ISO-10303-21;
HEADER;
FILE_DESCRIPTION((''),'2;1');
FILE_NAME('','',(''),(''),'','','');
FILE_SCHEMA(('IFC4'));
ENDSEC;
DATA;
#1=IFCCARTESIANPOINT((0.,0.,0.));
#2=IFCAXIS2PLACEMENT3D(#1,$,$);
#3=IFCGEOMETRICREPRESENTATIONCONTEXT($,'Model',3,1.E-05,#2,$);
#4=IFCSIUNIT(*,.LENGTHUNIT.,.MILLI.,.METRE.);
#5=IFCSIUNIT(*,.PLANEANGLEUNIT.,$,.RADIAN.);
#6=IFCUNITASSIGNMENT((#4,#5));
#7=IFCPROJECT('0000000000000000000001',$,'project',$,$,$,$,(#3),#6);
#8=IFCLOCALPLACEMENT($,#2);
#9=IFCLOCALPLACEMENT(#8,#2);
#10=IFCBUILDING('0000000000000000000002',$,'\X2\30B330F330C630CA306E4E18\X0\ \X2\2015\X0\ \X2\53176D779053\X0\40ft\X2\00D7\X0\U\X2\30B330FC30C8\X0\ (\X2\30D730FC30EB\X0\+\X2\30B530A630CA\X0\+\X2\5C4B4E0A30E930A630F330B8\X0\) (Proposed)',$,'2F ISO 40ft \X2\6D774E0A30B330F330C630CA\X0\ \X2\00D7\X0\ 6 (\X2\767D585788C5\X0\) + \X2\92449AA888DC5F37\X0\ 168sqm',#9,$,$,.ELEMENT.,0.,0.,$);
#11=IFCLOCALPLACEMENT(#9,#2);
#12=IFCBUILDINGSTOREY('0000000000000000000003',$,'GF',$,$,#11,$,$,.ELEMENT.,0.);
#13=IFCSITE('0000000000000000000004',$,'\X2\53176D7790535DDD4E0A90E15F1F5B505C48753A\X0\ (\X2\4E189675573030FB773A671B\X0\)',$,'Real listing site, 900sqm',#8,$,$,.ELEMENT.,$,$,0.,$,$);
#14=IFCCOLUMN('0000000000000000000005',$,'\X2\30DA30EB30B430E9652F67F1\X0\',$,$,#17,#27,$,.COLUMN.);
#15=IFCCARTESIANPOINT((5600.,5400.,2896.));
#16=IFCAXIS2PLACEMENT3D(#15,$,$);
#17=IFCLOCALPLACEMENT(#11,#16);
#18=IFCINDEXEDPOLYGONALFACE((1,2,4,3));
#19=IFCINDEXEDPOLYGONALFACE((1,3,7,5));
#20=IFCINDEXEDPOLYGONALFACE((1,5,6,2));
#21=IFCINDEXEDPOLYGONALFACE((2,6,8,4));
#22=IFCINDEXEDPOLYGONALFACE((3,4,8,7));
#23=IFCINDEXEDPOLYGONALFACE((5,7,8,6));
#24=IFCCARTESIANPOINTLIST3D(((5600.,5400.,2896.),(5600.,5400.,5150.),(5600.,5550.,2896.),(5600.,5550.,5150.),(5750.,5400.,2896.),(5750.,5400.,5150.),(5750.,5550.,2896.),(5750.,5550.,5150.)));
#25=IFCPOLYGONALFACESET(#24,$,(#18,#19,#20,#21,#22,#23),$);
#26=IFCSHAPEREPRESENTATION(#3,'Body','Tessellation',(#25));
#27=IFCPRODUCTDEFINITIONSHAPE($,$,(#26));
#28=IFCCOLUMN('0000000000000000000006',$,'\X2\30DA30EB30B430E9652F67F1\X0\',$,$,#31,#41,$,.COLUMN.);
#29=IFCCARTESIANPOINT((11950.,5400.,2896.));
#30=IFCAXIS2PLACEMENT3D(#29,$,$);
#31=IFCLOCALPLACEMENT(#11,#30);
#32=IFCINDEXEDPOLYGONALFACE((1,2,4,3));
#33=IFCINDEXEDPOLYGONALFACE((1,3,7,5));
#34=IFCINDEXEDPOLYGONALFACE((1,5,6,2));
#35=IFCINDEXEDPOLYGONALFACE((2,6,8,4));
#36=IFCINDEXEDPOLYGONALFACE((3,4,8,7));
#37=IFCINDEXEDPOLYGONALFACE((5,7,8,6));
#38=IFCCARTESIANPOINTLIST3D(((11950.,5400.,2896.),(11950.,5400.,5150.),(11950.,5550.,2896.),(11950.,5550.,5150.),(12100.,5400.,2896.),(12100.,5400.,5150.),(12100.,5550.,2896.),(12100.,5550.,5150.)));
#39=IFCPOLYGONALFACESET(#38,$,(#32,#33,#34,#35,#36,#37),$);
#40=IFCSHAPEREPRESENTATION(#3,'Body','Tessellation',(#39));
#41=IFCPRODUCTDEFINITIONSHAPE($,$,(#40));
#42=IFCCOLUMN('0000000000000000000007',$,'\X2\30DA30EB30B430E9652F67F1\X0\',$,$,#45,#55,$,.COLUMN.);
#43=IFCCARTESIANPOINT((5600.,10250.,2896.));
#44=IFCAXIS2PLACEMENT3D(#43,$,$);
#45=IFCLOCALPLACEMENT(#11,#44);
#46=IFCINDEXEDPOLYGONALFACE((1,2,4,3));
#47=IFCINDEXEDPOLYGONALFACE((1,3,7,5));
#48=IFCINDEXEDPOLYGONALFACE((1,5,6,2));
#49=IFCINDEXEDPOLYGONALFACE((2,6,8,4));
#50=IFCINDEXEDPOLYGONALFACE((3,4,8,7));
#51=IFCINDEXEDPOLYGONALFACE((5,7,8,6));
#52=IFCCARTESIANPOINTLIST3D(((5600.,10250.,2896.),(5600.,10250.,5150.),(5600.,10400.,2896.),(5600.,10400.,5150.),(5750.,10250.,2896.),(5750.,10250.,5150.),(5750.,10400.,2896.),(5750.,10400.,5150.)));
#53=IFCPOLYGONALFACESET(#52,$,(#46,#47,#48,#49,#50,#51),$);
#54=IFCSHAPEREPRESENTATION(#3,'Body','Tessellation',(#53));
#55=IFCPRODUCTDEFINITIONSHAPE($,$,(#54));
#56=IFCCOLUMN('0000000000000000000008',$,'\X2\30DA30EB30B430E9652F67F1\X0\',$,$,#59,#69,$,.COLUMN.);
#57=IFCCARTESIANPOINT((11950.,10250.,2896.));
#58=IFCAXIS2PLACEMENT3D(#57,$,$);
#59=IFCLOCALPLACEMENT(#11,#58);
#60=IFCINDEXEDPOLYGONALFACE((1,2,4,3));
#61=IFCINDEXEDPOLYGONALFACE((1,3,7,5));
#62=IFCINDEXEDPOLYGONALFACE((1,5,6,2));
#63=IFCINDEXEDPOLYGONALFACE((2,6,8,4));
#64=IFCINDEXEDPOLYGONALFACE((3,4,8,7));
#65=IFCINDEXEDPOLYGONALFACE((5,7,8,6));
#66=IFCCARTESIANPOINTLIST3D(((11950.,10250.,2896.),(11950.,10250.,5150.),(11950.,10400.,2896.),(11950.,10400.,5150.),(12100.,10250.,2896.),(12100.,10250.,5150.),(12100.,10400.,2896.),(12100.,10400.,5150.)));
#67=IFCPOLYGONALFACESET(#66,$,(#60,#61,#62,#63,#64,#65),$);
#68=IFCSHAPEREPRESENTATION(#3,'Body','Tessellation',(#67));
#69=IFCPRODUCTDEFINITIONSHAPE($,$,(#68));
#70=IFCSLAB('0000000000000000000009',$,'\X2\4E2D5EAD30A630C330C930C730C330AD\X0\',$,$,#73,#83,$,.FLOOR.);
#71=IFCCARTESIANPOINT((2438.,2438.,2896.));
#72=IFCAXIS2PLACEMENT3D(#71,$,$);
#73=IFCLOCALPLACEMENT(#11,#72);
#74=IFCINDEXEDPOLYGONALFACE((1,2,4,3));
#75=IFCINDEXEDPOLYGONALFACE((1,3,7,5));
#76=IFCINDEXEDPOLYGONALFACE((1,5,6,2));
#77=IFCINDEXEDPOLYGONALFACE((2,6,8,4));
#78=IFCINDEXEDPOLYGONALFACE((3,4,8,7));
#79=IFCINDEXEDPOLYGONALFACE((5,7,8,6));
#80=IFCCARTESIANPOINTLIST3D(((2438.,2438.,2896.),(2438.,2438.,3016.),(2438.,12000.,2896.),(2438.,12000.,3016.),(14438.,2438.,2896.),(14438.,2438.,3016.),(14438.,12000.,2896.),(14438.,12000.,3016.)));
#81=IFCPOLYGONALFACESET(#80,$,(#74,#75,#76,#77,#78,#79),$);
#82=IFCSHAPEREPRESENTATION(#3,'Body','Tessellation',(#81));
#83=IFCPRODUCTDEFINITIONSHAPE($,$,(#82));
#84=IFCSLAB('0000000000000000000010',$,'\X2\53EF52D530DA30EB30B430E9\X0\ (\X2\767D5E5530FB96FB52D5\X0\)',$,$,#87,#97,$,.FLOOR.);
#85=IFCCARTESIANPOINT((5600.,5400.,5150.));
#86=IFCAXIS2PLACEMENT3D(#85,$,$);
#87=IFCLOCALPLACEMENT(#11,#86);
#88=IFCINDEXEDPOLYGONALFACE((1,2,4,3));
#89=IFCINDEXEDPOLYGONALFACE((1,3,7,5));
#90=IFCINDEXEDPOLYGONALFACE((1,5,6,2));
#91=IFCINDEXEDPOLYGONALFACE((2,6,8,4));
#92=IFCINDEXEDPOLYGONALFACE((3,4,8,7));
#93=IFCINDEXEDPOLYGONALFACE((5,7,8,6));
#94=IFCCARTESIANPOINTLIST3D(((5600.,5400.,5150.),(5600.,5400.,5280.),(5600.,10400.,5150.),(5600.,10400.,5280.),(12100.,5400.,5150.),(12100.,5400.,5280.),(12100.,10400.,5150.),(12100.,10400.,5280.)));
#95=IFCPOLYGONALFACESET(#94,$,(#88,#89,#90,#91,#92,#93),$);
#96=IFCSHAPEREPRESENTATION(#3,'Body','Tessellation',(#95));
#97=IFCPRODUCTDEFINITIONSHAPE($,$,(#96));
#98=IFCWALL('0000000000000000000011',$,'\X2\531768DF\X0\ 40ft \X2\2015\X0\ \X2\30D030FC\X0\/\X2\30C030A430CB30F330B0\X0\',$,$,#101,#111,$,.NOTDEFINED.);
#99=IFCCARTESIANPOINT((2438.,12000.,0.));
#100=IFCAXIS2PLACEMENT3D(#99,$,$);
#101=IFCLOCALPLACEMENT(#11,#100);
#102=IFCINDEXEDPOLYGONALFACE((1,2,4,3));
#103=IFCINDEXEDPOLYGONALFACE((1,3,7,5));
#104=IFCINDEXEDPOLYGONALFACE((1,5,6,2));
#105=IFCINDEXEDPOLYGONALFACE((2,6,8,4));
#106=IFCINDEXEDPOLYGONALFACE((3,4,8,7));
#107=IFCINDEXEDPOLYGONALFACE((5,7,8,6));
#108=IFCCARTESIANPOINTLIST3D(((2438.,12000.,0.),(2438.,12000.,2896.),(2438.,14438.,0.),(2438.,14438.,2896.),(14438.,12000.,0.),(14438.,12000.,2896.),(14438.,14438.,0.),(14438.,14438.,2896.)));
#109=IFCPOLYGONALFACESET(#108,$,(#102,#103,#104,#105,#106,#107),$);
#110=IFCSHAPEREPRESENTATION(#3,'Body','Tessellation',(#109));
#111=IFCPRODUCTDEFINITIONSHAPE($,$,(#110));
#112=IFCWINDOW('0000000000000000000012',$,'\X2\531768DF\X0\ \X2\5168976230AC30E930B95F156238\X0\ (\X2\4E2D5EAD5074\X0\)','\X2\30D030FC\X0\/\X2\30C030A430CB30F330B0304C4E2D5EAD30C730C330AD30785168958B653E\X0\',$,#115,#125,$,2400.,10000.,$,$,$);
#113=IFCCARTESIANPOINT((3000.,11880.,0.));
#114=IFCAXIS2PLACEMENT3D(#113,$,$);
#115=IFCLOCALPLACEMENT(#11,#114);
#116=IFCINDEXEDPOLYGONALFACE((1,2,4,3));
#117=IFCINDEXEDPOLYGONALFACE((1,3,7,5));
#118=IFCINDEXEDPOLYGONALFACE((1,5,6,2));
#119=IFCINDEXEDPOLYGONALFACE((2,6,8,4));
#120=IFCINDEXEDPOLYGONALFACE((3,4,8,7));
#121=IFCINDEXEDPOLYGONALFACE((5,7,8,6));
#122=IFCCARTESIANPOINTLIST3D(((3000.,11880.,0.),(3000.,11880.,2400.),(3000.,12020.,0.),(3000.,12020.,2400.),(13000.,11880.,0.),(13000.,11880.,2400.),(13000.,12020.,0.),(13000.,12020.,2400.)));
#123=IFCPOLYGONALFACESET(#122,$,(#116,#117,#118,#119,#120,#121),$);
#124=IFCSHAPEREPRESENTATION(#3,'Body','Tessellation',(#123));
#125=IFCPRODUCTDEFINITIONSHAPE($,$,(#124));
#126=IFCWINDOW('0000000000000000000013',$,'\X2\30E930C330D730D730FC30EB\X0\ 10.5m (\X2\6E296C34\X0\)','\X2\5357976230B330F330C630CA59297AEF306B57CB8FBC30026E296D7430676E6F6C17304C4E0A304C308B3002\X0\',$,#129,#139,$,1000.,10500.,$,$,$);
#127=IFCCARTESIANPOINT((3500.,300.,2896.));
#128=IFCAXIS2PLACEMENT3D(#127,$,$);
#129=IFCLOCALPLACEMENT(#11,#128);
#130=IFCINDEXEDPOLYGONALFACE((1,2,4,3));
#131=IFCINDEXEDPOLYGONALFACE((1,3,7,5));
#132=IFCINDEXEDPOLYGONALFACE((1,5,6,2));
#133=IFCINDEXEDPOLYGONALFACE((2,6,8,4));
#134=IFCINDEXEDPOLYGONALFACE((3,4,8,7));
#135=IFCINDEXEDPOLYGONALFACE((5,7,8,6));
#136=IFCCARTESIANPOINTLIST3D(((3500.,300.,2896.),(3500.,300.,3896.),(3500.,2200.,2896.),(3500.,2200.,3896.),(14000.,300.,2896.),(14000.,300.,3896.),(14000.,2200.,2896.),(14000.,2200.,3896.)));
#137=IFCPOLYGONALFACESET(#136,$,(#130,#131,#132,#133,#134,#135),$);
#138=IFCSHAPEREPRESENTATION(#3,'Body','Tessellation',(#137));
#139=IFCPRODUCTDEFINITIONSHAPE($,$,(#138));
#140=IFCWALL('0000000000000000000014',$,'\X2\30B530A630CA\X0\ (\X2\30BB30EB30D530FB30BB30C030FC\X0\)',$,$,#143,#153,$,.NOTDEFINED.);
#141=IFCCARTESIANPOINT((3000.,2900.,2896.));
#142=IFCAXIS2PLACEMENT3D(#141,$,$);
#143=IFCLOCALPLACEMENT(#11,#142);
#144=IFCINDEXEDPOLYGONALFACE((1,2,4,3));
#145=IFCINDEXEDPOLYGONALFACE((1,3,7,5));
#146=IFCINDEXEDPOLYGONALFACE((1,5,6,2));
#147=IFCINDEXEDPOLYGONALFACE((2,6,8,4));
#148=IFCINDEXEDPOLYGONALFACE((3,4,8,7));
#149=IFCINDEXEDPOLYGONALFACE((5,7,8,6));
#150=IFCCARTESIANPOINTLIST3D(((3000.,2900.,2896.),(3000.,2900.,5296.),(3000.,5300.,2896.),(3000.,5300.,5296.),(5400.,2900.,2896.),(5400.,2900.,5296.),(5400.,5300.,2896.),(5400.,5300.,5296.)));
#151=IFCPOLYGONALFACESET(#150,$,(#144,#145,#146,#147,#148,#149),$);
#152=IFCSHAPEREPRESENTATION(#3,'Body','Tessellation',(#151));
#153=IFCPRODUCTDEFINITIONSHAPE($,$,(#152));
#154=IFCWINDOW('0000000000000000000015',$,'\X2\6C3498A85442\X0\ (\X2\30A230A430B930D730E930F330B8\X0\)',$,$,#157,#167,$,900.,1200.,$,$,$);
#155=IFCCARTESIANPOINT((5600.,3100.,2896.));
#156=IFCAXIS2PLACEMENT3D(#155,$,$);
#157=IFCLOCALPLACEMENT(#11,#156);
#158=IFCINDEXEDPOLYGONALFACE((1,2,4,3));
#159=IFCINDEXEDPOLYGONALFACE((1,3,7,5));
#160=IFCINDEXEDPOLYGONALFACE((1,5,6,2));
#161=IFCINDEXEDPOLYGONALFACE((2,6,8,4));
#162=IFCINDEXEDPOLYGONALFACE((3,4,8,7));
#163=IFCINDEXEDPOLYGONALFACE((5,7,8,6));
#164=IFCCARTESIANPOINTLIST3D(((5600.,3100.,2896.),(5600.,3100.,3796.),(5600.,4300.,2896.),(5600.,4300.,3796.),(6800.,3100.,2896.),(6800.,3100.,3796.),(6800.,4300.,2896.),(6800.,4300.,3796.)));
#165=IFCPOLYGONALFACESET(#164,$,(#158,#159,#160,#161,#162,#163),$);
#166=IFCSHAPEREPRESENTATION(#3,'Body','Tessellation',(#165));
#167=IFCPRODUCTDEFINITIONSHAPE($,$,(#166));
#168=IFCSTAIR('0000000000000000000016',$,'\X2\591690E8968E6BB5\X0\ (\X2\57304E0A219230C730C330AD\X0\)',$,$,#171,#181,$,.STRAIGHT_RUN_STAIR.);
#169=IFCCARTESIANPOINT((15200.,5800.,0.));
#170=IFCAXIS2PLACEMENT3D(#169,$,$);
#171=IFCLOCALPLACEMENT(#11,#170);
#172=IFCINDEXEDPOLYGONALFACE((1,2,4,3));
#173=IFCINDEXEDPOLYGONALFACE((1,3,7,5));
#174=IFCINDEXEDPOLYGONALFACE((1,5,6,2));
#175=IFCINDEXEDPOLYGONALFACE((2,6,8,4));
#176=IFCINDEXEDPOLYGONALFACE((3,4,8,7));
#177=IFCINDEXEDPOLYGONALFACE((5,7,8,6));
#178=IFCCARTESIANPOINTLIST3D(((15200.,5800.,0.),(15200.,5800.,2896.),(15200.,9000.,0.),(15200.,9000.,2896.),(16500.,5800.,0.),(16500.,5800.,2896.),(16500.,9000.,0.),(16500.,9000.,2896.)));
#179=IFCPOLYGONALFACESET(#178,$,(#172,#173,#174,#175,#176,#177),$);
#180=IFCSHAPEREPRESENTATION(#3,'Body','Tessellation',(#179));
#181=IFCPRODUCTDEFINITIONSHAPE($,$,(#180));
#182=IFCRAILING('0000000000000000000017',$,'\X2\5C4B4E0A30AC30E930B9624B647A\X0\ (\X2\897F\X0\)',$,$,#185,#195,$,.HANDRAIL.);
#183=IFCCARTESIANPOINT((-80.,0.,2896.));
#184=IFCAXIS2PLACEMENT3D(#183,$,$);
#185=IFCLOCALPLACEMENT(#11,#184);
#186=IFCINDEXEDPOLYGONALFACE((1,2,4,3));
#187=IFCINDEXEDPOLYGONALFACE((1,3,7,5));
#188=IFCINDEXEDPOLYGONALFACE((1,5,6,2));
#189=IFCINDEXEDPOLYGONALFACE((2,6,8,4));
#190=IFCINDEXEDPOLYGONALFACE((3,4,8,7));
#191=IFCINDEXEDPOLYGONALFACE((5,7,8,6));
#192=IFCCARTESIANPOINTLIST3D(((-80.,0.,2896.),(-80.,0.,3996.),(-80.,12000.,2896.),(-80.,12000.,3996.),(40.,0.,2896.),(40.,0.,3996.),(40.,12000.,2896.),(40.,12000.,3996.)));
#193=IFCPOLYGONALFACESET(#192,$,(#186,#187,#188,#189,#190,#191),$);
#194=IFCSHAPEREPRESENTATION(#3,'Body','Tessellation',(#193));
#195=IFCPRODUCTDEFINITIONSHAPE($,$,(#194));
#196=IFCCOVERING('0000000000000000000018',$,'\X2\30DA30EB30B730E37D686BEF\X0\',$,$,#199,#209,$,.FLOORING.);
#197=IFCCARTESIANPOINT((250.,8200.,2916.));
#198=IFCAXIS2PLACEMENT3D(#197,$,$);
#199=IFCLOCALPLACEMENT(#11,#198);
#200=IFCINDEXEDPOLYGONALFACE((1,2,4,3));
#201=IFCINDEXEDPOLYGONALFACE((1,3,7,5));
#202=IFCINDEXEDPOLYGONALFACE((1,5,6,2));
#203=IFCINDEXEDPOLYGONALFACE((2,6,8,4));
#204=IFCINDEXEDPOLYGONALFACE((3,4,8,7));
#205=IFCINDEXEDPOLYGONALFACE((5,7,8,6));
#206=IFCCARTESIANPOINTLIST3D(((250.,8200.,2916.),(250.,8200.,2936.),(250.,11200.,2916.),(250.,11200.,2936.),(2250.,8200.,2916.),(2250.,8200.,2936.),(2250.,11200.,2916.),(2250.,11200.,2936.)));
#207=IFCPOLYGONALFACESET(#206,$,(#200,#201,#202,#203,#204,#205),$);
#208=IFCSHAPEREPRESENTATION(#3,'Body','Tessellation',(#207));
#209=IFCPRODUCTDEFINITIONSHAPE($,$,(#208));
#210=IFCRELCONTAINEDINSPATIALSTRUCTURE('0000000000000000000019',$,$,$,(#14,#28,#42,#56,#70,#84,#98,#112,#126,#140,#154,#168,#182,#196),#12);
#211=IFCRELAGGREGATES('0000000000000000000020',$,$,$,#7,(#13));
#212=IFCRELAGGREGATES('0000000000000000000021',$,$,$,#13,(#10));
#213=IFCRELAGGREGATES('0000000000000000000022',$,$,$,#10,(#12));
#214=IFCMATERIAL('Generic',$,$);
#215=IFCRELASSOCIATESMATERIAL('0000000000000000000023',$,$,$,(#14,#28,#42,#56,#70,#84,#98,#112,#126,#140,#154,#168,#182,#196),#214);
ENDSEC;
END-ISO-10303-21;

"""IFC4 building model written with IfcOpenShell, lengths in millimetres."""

from ifc_helpers import new_model, si_unit, frame, frame_2d, origin, place, context, project, spatial, rectangle, extrude, material, element, fill, save


model = new_model("IFC4")

# Units and contexts
model_context = context("Model", 3, precision=1e-05, world=origin())
ifc_project = project(units=[si_unit("LENGTHUNIT", "METRE", prefix="MILLI"), si_unit("PLANEANGLEUNIT", "RADIAN")], contexts=[model_context])

# Site, building, storey
site_placement = place(None, origin())
site = spatial("IfcSite", under=ifc_project, at=site_placement, Name="北海道川上郡弟子屈町 (丘陵地・眺望)", ObjectType="Real listing site, 900sqm", CompositionType="ELEMENT", RefElevation=0.0)
building_placement = place(site_placement, origin())
building = spatial("IfcBuilding", under=site, at=building_placement, Name="コンテナの丘 ― 北海道40ft×Uコート (プール+サウナ+屋上ラウンジ) (Proposed)", ObjectType="2F ISO 40ft 海上コンテナ × 6 (白塗装) + 鉄骨補強 168sqm", CompositionType="ELEMENT", ElevationOfRefHeight=0.0, ElevationOfTerrain=0.0)
storey_placement = place(building_placement, origin())
storey = spatial("IfcBuildingStorey", under=building, at=storey_placement, Name="GF", CompositionType="ELEMENT", Elevation=0.0)

# Columns
ifc_material = material(Name="Generic")
column_1_placement = place(storey_placement, frame((5600.0, 5400.0, 2896.0)))
element("IfcColumn", 1, at=column_1_placement, inside=storey, material=ifc_material, Name="ペルゴラ支柱", PredefinedType="COLUMN", context=model_context, shape_type="SweptSolid", body=[
    extrude(rectangle(XDim=150.0, YDim=150.0, at=frame_2d((75.0, 75.0))), frame((5600.0, 5400.0, 2896.0)), (0.0, 0.0, 1.0), 2254.0),
])
column_2_placement = place(storey_placement, frame((11950.0, 5400.0, 2896.0)))
element("IfcColumn", 2, at=column_2_placement, inside=storey, material=ifc_material, Name="ペルゴラ支柱", PredefinedType="COLUMN", context=model_context, shape_type="SweptSolid", body=[
    extrude(rectangle(XDim=150.0, YDim=150.0, at=frame_2d((75.0, 75.0))), frame((11950.0, 5400.0, 2896.0)), (0.0, 0.0, 1.0), 2254.0),
])
column_3_placement = place(storey_placement, frame((5600.0, 10250.0, 2896.0)))
element("IfcColumn", 3, at=column_3_placement, inside=storey, material=ifc_material, Name="ペルゴラ支柱", PredefinedType="COLUMN", context=model_context, shape_type="SweptSolid", body=[
    extrude(rectangle(XDim=150.0, YDim=150.0, at=frame_2d((75.0, 75.0))), frame((5600.0, 10250.0, 2896.0)), (0.0, 0.0, 1.0), 2254.0),
])
column_4_placement = place(storey_placement, frame((11950.0, 10250.0, 2896.0)))
element("IfcColumn", 4, at=column_4_placement, inside=storey, material=ifc_material, Name="ペルゴラ支柱", PredefinedType="COLUMN", context=model_context, shape_type="SweptSolid", body=[
    extrude(rectangle(XDim=150.0, YDim=150.0, at=frame_2d((75.0, 75.0))), frame((11950.0, 10250.0, 2896.0)), (0.0, 0.0, 1.0), 2254.0),
])

# Slabs
slab_1_placement = place(storey_placement, frame((2438.0, 2438.0, 2896.0)))
element("IfcSlab", 5, at=slab_1_placement, inside=storey, material=ifc_material, Name="中庭ウッドデッキ", PredefinedType="FLOOR", context=model_context, shape_type="SweptSolid", body=[
    extrude(rectangle(XDim=12000.0, YDim=9562.0, at=frame_2d((6000.0, 4781.0))), frame((2438.0, 2438.0, 2896.0)), (0.0, 0.0, 1.0), 120.0),
])
slab_2_placement = place(storey_placement, frame((5600.0, 5400.0, 5150.0)))
element("IfcSlab", 6, at=slab_2_placement, inside=storey, material=ifc_material, Name="可動ペルゴラ (白幕・電動)", PredefinedType="FLOOR", context=model_context, shape_type="SweptSolid", body=[
    extrude(rectangle(XDim=6500.0, YDim=5000.0, at=frame_2d((3250.0, 2500.0))), frame((5600.0, 5400.0, 5150.0)), (0.0, 0.0, 1.0), 130.0),
])

# Wall, opening, window
wall_1_placement = place(storey_placement, frame((2438.0, 12000.0, 0.0)))
wall_1 = element("IfcWall", 7, at=wall_1_placement, inside=storey, material=ifc_material, Name="北棟 40ft ― バー/ダイニング", PredefinedType="NOTDEFINED", context=model_context, shape_type="SweptSolid", body=[
    extrude(rectangle(XDim=12000.0, YDim=2438.0, at=frame_2d((6000.0, 1219.0))), frame((2438.0, 12000.0, 0.0)), (0.0, 0.0, 1.0), 2896.0),
])
opening_1_placement = place(storey_placement, frame((3000.0, 11880.0, 0.0)))
opening_1 = element("IfcOpeningElement", 8, at=opening_1_placement, cuts=wall_1, PredefinedType="NOTDEFINED", context=model_context, shape_type="SweptSolid", body=[
    extrude(rectangle(XDim=10000.0, YDim=140.0, at=frame_2d((5000.0, 70.0))), frame((3000.0, 11880.0, 0.0)), (0.0, 0.0, 1.0), 2400.0),
])
window_1_placement = place(storey_placement, frame((3000.0, 11880.0, 0.0)))
window_1 = element("IfcWindow", 9, at=window_1_placement, inside=storey, material=ifc_material, Name="北棟 全面ガラス引戸 (中庭側)", Description="バー/ダイニングが中庭デッキへ全開放", OverallHeight=2400.0, OverallWidth=10000.0, context=model_context, shape_type="SweptSolid", body=[
    extrude(rectangle(XDim=10000.0, YDim=140.0, at=frame_2d((5000.0, 70.0))), frame((3000.0, 11880.0, 0.0)), (0.0, 0.0, 1.0), 2400.0),
])
fill(opening_1, window_1)

# Window
window_2_placement = place(storey_placement, frame((3500.0, 300.0, 2896.0)))
element("IfcWindow", 10, at=window_2_placement, inside=storey, material=ifc_material, Name="ラッププール 10.5m (温水)", Description="南面コンテナ天端に埋込。温浴で湯気が上がる。", OverallHeight=1000.0, OverallWidth=10500.0, context=model_context, shape_type="SweptSolid", body=[
    extrude(rectangle(XDim=10500.0, YDim=1900.0, at=frame_2d((5250.0, 950.0))), frame((3500.0, 300.0, 2896.0)), (0.0, 0.0, 1.0), 1000.0),
])

# Wall
wall_2_placement = place(storey_placement, frame((3000.0, 2900.0, 2896.0)))
element("IfcWall", 11, at=wall_2_placement, inside=storey, material=ifc_material, Name="サウナ (セルフ・セダー)", PredefinedType="NOTDEFINED", context=model_context, shape_type="SweptSolid", body=[
    extrude(rectangle(XDim=2400.0, YDim=2400.0, at=frame_2d((1200.0, 1200.0))), frame((3000.0, 2900.0, 2896.0)), (0.0, 0.0, 1.0), 2400.0),
])

# Window
window_3_placement = place(storey_placement, frame((5600.0, 3100.0, 2896.0)))
element("IfcWindow", 12, at=window_3_placement, inside=storey, material=ifc_material, Name="水風呂 (アイスプランジ)", OverallHeight=900.0, OverallWidth=1200.0, context=model_context, shape_type="SweptSolid", body=[
    extrude(rectangle(XDim=1200.0, YDim=1200.0, at=frame_2d((600.0, 600.0))), frame((5600.0, 3100.0, 2896.0)), (0.0, 0.0, 1.0), 900.0),
])

# Stair
stair_placement = place(storey_placement, frame((15200.0, 5800.0, 0.0)))
element("IfcStair", 13, at=stair_placement, inside=storey, material=ifc_material, Name="外部階段 (地上→デッキ)", PredefinedType="STRAIGHT_RUN_STAIR", context=model_context, shape_type="SweptSolid", body=[
    extrude(rectangle(XDim=1300.0, YDim=3200.0, at=frame_2d((650.0, 1600.0))), frame((15200.0, 5800.0, 0.0)), (0.0, 0.0, 1.0), 2896.0),
])

# Railing
railing_placement = place(storey_placement, frame((-80.0, 0.0, 2896.0)))
element("IfcRailing", 14, at=railing_placement, inside=storey, material=ifc_material, Name="屋上ガラス手摺 (西)", PredefinedType="HANDRAIL", context=model_context, shape_type="SweptSolid", body=[
    extrude(rectangle(XDim=120.0, YDim=12000.0, at=frame_2d((60.0, 6000.0))), frame((-80.0, 0.0, 2896.0)), (0.0, 0.0, 1.0), 1100.0),
])

# Covering
covering_placement = place(storey_placement, frame((250.0, 8200.0, 2916.0)))
element("IfcCovering", 15, at=covering_placement, inside=storey, material=ifc_material, Name="ペルシャ絨毯", PredefinedType="FLOORING", context=model_context, shape_type="SweptSolid", body=[
    extrude(rectangle(XDim=2000.0, YDim=3000.0, at=frame_2d((1000.0, 1500.0))), frame((250.0, 8200.0, 2916.0)), (0.0, 0.0, 1.0), 20.0),
])

save(model, "model.ifc")
